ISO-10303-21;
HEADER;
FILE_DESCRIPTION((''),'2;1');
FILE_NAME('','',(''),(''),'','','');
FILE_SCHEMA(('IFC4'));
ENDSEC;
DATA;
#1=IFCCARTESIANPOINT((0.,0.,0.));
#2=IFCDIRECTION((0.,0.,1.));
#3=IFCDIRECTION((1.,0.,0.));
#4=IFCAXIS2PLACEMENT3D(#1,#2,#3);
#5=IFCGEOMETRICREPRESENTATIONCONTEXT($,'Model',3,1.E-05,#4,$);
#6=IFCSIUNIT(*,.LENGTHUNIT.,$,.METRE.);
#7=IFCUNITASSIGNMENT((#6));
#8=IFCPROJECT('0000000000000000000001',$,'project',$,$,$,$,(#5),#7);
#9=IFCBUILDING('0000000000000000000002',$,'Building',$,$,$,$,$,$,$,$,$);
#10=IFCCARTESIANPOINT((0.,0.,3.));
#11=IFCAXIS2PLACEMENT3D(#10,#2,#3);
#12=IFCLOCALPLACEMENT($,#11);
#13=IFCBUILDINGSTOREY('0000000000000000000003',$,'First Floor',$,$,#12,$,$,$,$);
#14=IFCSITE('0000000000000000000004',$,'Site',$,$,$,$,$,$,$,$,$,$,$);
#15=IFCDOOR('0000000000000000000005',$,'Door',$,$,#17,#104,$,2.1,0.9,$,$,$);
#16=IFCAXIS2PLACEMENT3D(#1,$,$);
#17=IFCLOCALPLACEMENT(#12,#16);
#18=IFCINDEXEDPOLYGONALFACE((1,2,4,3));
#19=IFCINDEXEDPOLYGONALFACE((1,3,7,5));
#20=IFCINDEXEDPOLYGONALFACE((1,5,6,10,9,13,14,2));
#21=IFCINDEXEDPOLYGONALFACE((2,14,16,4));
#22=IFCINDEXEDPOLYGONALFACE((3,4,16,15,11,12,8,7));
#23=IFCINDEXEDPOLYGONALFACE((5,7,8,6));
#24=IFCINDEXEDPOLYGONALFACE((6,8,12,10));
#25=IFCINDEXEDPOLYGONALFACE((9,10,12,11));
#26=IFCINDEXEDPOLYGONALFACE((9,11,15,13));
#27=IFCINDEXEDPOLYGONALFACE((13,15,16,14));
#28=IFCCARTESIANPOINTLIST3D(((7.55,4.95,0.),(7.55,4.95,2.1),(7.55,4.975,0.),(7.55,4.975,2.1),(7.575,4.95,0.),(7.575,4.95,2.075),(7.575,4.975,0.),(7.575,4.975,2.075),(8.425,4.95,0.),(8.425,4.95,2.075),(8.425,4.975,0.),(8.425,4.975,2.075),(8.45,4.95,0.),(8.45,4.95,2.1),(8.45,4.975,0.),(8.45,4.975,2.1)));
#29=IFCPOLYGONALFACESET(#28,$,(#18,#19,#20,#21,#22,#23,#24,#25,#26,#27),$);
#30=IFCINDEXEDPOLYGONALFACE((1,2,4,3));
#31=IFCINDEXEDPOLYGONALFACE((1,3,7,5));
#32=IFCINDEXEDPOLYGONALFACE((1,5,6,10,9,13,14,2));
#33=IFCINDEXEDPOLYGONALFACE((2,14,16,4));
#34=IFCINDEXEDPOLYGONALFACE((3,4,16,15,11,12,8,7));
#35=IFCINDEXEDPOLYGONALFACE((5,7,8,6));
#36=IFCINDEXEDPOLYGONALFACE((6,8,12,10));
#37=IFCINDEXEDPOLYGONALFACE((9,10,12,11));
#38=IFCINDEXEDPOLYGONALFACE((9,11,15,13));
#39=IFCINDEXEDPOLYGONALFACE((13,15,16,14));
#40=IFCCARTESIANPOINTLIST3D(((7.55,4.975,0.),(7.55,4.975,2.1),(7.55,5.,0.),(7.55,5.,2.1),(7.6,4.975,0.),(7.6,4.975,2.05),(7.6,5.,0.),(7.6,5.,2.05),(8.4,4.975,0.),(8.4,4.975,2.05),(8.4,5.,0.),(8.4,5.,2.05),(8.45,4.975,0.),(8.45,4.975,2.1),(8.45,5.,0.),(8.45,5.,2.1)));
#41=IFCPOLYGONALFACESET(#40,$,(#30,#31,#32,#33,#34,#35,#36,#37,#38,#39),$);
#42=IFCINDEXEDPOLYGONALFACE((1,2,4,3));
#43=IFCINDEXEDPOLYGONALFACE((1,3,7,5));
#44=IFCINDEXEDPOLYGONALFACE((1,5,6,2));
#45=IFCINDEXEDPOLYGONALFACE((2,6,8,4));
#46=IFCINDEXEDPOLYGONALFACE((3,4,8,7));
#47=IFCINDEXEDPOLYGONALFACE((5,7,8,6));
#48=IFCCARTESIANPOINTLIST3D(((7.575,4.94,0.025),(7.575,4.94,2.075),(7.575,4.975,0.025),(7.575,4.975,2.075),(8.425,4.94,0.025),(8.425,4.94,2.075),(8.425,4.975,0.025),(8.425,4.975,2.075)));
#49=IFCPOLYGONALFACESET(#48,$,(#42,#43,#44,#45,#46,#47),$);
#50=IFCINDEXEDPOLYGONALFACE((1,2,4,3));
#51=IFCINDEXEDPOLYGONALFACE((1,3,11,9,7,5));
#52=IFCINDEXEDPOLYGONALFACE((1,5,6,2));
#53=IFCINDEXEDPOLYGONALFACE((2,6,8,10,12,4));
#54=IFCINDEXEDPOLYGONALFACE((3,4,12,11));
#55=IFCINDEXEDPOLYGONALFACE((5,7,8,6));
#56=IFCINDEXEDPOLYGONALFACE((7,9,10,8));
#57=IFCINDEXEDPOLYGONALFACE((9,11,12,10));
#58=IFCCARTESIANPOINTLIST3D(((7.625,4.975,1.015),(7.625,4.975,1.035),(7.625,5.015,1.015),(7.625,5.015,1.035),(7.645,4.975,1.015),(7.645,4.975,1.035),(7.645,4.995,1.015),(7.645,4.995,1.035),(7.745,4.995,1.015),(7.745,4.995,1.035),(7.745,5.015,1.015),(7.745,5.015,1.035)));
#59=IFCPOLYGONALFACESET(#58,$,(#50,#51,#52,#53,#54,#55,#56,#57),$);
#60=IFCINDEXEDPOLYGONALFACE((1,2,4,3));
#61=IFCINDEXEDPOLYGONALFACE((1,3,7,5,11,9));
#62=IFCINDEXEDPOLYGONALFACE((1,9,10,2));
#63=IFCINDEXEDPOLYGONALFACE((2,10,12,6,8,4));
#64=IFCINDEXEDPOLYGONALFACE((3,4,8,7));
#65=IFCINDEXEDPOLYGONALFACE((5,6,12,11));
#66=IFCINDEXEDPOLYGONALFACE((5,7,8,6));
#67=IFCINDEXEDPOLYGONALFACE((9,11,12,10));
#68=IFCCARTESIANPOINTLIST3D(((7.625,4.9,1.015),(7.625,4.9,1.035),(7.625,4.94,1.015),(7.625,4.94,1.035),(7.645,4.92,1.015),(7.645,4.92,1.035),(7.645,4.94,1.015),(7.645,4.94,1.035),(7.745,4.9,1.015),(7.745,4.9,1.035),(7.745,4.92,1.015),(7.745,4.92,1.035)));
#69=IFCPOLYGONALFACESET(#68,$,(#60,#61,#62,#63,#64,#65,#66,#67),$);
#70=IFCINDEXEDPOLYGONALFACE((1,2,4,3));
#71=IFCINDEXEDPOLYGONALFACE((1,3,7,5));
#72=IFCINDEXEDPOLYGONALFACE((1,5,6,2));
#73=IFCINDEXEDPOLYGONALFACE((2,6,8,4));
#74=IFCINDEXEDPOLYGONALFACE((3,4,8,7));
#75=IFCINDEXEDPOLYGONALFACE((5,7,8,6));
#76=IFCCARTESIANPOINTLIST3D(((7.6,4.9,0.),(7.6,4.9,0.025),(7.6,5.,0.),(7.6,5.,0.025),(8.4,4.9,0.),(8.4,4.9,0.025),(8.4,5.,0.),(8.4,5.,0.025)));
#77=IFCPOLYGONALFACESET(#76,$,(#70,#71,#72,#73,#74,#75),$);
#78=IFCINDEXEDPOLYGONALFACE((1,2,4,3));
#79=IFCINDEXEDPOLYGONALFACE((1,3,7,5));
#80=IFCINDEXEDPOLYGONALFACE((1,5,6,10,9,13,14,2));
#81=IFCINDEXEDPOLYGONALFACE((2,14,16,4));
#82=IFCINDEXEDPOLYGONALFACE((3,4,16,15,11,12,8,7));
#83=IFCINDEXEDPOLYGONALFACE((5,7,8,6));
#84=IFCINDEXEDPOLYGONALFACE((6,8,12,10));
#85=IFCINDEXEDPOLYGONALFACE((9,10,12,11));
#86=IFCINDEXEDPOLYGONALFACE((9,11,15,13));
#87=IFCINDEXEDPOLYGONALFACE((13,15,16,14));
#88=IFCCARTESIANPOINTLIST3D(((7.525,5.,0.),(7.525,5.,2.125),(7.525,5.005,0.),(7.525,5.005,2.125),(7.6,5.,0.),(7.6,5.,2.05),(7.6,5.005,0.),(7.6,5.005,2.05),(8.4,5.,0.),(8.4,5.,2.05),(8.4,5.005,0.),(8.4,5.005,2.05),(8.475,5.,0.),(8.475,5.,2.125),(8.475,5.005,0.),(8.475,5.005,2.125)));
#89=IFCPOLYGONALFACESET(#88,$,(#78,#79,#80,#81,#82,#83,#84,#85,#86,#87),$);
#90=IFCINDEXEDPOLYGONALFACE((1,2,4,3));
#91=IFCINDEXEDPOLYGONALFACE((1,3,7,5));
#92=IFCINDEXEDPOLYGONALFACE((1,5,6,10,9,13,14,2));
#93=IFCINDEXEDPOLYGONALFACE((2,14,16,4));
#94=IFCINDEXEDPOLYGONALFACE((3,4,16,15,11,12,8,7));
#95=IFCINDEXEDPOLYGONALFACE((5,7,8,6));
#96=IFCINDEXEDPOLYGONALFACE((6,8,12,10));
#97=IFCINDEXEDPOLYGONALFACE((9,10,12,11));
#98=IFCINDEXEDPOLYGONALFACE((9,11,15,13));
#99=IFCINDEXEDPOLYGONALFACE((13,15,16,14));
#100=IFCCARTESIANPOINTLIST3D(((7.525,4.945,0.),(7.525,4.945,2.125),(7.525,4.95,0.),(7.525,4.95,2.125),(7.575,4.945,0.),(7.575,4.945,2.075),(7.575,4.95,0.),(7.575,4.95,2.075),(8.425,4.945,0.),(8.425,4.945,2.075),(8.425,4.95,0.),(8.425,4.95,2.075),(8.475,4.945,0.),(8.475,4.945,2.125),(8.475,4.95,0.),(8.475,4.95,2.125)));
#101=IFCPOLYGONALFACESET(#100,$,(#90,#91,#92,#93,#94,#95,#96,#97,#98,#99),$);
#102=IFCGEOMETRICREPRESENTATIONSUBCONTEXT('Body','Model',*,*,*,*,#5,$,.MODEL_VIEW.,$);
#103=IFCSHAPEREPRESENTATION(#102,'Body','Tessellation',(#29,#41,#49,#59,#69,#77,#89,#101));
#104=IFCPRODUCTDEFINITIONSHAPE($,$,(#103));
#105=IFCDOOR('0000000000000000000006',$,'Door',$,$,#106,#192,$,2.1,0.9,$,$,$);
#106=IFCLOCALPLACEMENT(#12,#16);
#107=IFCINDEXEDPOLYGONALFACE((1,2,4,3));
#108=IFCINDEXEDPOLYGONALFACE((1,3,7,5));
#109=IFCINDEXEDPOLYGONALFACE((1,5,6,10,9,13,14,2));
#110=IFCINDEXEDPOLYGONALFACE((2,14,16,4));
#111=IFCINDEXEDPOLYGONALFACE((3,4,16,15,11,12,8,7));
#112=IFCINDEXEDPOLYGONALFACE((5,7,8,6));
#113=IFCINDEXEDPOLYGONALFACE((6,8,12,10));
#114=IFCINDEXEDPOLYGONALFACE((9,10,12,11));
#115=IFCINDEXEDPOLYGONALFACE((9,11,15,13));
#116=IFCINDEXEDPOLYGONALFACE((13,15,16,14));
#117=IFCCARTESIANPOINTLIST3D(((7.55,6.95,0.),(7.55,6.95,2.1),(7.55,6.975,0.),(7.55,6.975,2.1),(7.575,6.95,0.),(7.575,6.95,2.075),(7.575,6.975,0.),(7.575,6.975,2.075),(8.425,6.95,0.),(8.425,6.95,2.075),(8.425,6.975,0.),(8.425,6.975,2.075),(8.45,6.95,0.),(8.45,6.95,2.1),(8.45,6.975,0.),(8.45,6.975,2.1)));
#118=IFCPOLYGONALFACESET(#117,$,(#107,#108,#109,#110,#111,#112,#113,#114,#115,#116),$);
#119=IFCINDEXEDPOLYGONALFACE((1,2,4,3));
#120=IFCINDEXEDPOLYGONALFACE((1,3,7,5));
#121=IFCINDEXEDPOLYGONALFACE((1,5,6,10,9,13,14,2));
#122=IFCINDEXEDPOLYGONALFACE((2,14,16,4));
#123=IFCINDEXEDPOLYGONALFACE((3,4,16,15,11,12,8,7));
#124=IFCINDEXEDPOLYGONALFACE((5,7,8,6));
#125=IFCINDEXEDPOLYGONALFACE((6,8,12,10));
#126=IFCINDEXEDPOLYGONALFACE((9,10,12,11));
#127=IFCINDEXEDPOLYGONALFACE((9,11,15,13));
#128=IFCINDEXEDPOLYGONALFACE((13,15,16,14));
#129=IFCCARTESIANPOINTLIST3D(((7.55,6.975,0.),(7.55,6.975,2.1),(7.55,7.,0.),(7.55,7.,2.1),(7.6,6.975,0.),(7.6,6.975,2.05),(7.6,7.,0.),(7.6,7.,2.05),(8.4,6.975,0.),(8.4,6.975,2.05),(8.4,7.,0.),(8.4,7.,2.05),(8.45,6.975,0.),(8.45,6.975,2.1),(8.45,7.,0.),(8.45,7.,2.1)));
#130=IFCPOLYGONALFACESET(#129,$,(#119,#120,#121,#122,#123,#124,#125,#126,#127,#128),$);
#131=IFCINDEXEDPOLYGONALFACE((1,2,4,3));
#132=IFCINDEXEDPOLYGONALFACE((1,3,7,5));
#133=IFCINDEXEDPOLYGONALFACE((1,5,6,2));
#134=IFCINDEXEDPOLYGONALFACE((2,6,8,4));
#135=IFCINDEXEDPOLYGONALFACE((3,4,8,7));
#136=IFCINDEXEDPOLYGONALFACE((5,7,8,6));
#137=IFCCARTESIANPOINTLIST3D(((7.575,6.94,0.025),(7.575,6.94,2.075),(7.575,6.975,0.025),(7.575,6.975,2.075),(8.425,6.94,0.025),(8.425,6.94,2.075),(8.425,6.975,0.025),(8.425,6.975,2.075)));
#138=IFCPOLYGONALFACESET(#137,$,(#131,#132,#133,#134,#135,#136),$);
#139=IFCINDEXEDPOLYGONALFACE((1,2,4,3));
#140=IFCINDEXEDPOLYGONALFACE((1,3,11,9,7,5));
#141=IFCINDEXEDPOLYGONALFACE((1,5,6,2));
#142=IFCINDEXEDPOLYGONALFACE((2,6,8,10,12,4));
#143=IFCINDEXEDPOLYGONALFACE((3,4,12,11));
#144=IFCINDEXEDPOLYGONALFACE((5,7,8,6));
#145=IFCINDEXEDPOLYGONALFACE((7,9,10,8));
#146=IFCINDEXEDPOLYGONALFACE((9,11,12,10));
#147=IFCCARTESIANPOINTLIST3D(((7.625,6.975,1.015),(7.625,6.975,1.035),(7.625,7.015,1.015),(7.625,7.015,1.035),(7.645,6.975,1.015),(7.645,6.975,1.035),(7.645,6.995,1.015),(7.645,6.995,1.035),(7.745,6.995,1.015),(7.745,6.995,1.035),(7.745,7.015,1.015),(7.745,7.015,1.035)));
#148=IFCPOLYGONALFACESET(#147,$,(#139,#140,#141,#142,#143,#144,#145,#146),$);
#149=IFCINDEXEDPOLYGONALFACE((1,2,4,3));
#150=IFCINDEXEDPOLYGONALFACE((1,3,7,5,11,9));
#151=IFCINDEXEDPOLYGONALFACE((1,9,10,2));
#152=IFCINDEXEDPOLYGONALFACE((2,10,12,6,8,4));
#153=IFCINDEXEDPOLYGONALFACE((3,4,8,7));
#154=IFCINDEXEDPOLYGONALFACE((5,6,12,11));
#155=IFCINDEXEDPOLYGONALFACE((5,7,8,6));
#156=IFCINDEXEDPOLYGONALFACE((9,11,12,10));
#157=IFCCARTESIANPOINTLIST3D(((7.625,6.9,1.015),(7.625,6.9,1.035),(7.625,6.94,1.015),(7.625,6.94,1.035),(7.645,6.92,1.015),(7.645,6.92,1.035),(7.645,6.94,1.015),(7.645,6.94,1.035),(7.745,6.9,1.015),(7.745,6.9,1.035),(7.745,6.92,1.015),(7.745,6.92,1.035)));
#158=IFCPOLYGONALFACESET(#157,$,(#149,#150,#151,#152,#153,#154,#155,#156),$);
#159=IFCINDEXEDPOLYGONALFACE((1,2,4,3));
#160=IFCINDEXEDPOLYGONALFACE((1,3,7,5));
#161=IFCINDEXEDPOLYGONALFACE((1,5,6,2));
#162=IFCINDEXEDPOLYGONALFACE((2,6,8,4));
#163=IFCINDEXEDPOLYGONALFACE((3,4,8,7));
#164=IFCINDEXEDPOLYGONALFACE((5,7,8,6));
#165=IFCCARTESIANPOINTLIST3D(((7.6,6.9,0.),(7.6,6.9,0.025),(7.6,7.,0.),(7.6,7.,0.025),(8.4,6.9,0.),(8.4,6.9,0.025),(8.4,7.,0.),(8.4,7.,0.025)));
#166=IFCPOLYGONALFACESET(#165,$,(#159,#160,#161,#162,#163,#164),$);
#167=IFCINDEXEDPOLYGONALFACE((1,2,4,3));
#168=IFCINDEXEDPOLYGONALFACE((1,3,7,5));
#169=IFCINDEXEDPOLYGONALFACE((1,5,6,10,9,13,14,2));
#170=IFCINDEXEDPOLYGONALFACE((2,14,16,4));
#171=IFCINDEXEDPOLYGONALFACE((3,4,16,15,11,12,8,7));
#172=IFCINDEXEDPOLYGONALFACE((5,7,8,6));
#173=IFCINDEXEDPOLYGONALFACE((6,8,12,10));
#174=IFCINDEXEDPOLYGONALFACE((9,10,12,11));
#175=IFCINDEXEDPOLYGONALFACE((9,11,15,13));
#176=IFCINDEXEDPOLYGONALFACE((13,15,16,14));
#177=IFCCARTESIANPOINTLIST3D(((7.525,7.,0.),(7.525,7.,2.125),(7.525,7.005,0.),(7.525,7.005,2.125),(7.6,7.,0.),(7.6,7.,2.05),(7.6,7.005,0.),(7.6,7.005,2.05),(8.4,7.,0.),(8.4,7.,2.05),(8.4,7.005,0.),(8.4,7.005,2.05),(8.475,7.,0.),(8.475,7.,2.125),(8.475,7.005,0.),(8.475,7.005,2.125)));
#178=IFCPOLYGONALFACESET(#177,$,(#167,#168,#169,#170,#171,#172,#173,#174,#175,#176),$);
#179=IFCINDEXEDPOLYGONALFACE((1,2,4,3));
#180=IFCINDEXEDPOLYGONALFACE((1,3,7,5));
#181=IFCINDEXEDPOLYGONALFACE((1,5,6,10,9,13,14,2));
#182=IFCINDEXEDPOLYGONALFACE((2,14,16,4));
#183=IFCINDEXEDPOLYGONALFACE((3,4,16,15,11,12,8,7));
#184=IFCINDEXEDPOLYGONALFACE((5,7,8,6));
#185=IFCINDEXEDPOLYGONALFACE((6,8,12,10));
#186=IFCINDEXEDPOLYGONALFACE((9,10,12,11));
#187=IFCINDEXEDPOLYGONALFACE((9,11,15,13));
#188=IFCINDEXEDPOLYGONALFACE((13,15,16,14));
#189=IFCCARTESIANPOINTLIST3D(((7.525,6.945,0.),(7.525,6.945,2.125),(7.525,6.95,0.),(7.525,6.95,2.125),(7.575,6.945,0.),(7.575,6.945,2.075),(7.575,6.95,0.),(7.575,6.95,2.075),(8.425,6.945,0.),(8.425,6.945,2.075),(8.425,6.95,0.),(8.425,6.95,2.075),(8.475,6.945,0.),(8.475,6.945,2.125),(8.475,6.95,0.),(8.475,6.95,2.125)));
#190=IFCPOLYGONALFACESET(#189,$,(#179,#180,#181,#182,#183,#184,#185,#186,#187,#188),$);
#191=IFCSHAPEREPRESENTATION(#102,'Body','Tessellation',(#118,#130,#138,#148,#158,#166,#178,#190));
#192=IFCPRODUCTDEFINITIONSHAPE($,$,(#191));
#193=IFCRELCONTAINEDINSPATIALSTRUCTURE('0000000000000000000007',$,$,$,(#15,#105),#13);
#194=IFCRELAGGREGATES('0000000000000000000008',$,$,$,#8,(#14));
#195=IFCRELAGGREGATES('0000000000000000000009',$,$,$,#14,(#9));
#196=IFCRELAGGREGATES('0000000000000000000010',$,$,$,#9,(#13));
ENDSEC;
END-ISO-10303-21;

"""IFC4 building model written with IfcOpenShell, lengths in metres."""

from ifc_helpers import new_model, si_unit, frame, origin_with_axes, place, context, subcontext, project, spatial, line, indexed_curve, outline, extrude, element, save


model = new_model("IFC4")

# Units and contexts
model_context = context("Model", 3, precision=1e-05, world=origin_with_axes())
body_context = subcontext(model_context, "Body", "Model", "MODEL_VIEW")
ifc_project = project(units=[si_unit("LENGTHUNIT", "METRE")], contexts=[model_context])

# Site, building, storey
site = spatial("IfcSite", under=ifc_project, Name="Site")
building = spatial("IfcBuilding", under=site, Name="Building")
storey_placement = place(None, frame((0.0, 0.0, 3.0), z_axis=(0.0, 0.0, 1.0), x_axis=(1.0, 0.0, 0.0)))
storey = spatial("IfcBuildingStorey", under=building, at=storey_placement, Name="First Floor")

# Doors
door_1_placement = place(storey_placement, frame((8.45, 5.0, 0.0), z_axis=(0.0, 0.0, 1.0), x_axis=(-1.0, 0.0, 0.0)))
element("IfcDoor", 1, at=door_1_placement, inside=storey, Name="Door", OverallHeight=2.1, OverallWidth=0.9, context=body_context, shape_type="SweptSolid", body=[
    extrude(outline(indexed_curve([(0.0, 0.0), (0.0, 2.1), (0.9, 2.1), (0.9, 0.0), (0.875, 0.0), (0.875, 2.075), (0.025, 2.075), (0.025, 0.0)], segments=[line(1, 2, 3, 4, 5, 6, 7, 8, 1)])), frame((0.0, 0.025, 0.0), z_axis=(0.0, -1.0, 0.0), x_axis=(1.0, 0.0, 0.0)), (0.0, 0.0, -1.0), 0.025),
    extrude(outline(indexed_curve([(0.0, 0.0), (0.0, 2.1), (0.9, 2.1), (0.9, 0.0), (0.85, 0.0), (0.85, 2.05), (0.05, 2.05), (0.05, 0.0)], segments=[line(1, 2, 3, 4, 5, 6, 7, 8, 1)])), frame((0.0, 0.0, 0.0), z_axis=(0.0, -1.0, 0.0), x_axis=(1.0, 0.0, 0.0)), (0.0, 0.0, -1.0), 0.025),
    extrude(outline(indexed_curve([(0.0, 0.0), (0.85, 0.0), (0.85, 0.035), (0.0, 0.035)], segments=[line(1, 2, 3, 4, 1)])), frame((0.025, 0.025, 0.025), z_axis=(0.0, 0.0, 1.0), x_axis=(1.0, 0.0, 0.0)), (0.0, 0.0, 1.0), 2.05),
    extrude(outline(indexed_curve([(0.0, 0.0), (0.0, -0.04), (-0.12, -0.04), (-0.12, -0.02), (-0.02, -0.02), (-0.02, 0.0)], segments=[line(1, 2, 3, 4, 5, 6, 1)])), frame((0.825, 0.025, 1.015), z_axis=(0.0, 0.0, 1.0), x_axis=(1.0, 0.0, 0.0)), (0.0, 0.0, 1.0), 0.02),
    extrude(outline(indexed_curve([(0.0, 0.0), (0.0, 0.04), (-0.12, 0.04), (-0.12, 0.02), (-0.02, 0.02), (-0.02, 0.0)], segments=[line(1, 2, 3, 4, 5, 6, 1)])), frame((0.825, 0.06, 1.015), z_axis=(0.0, 0.0, 1.0), x_axis=(1.0, 0.0, 0.0)), (0.0, 0.0, 1.0), 0.02),
    extrude(outline(indexed_curve([(0.0, 0.0), (0.8, 0.0), (0.8, 0.1), (0.0, 0.1)], segments=[line(1, 2, 3, 4, 1)])), frame((0.05, 0.0, 0.0), z_axis=(0.0, 0.0, 1.0), x_axis=(1.0, 0.0, 0.0)), (0.0, 0.0, 1.0), 0.025),
    extrude(outline(indexed_curve([(0.0, 0.0), (0.0, 2.125), (0.95, 2.125), (0.95, 0.0), (0.875, 0.0), (0.875, 2.05), (0.075, 2.05), (0.075, 0.0)], segments=[line(1, 2, 3, 4, 5, 6, 7, 8, 1)])), frame((-0.025, -0.005, 0.0), z_axis=(0.0, -1.0, 0.0), x_axis=(1.0, 0.0, 0.0)), (0.0, 0.0, -1.0), 0.005),
    extrude(outline(indexed_curve([(0.0, 0.0), (0.0, 2.125), (0.95, 2.125), (0.95, 0.0), (0.9, 0.0), (0.9, 2.075), (0.05, 2.075), (0.05, 0.0)], segments=[line(1, 2, 3, 4, 5, 6, 7, 8, 1)])), frame((-0.025, 0.05, 0.0), z_axis=(0.0, -1.0, 0.0), x_axis=(1.0, 0.0, 0.0)), (0.0, 0.0, -1.0), 0.005),
])
door_2_placement = place(storey_placement, frame((8.45, 7.0, 0.0), z_axis=(0.0, 0.0, 1.0), x_axis=(-1.0, 0.0, 0.0)))
element("IfcDoor", 2, at=door_2_placement, inside=storey, Name="Door", OverallHeight=2.1, OverallWidth=0.9, context=body_context, shape_type="SweptSolid", body=[
    extrude(outline(indexed_curve([(0.0, 0.0), (0.0, 2.1), (0.9, 2.1), (0.9, 0.0), (0.875, 0.0), (0.875, 2.075), (0.025, 2.075), (0.025, 0.0)], segments=[line(1, 2, 3, 4, 5, 6, 7, 8, 1)])), frame((0.0, 0.025, 0.0), z_axis=(0.0, -1.0, 0.0), x_axis=(1.0, 0.0, 0.0)), (0.0, 0.0, -1.0), 0.025),
    extrude(outline(indexed_curve([(0.0, 0.0), (0.0, 2.1), (0.9, 2.1), (0.9, 0.0), (0.85, 0.0), (0.85, 2.05), (0.05, 2.05), (0.05, 0.0)], segments=[line(1, 2, 3, 4, 5, 6, 7, 8, 1)])), frame((0.0, 0.0, 0.0), z_axis=(0.0, -1.0, 0.0), x_axis=(1.0, 0.0, 0.0)), (0.0, 0.0, -1.0), 0.025),
    extrude(outline(indexed_curve([(0.0, 0.0), (0.85, 0.0), (0.85, 0.035), (0.0, 0.035)], segments=[line(1, 2, 3, 4, 1)])), frame((0.025, 0.025, 0.025), z_axis=(0.0, 0.0, 1.0), x_axis=(1.0, 0.0, 0.0)), (0.0, 0.0, 1.0), 2.05),
    extrude(outline(indexed_curve([(0.0, 0.0), (0.0, -0.04), (-0.12, -0.04), (-0.12, -0.02), (-0.02, -0.02), (-0.02, 0.0)], segments=[line(1, 2, 3, 4, 5, 6, 1)])), frame((0.825, 0.025, 1.015), z_axis=(0.0, 0.0, 1.0), x_axis=(1.0, 0.0, 0.0)), (0.0, 0.0, 1.0), 0.02),
    extrude(outline(indexed_curve([(0.0, 0.0), (0.0, 0.04), (-0.12, 0.04), (-0.12, 0.02), (-0.02, 0.02), (-0.02, 0.0)], segments=[line(1, 2, 3, 4, 5, 6, 1)])), frame((0.825, 0.06, 1.015), z_axis=(0.0, 0.0, 1.0), x_axis=(1.0, 0.0, 0.0)), (0.0, 0.0, 1.0), 0.02),
    extrude(outline(indexed_curve([(0.0, 0.0), (0.8, 0.0), (0.8, 0.1), (0.0, 0.1)], segments=[line(1, 2, 3, 4, 1)])), frame((0.05, 0.0, 0.0), z_axis=(0.0, 0.0, 1.0), x_axis=(1.0, 0.0, 0.0)), (0.0, 0.0, 1.0), 0.025),
    extrude(outline(indexed_curve([(0.0, 0.0), (0.0, 2.125), (0.95, 2.125), (0.95, 0.0), (0.875, 0.0), (0.875, 2.05), (0.075, 2.05), (0.075, 0.0)], segments=[line(1, 2, 3, 4, 5, 6, 7, 8, 1)])), frame((-0.025, -0.005, 0.0), z_axis=(0.0, -1.0, 0.0), x_axis=(1.0, 0.0, 0.0)), (0.0, 0.0, -1.0), 0.005),
    extrude(outline(indexed_curve([(0.0, 0.0), (0.0, 2.125), (0.95, 2.125), (0.95, 0.0), (0.9, 0.0), (0.9, 2.075), (0.05, 2.075), (0.05, 0.0)], segments=[line(1, 2, 3, 4, 5, 6, 7, 8, 1)])), frame((-0.025, 0.05, 0.0), z_axis=(0.0, -1.0, 0.0), x_axis=(1.0, 0.0, 0.0)), (0.0, 0.0, -1.0), 0.005),
])

save(model, "model.ifc")
